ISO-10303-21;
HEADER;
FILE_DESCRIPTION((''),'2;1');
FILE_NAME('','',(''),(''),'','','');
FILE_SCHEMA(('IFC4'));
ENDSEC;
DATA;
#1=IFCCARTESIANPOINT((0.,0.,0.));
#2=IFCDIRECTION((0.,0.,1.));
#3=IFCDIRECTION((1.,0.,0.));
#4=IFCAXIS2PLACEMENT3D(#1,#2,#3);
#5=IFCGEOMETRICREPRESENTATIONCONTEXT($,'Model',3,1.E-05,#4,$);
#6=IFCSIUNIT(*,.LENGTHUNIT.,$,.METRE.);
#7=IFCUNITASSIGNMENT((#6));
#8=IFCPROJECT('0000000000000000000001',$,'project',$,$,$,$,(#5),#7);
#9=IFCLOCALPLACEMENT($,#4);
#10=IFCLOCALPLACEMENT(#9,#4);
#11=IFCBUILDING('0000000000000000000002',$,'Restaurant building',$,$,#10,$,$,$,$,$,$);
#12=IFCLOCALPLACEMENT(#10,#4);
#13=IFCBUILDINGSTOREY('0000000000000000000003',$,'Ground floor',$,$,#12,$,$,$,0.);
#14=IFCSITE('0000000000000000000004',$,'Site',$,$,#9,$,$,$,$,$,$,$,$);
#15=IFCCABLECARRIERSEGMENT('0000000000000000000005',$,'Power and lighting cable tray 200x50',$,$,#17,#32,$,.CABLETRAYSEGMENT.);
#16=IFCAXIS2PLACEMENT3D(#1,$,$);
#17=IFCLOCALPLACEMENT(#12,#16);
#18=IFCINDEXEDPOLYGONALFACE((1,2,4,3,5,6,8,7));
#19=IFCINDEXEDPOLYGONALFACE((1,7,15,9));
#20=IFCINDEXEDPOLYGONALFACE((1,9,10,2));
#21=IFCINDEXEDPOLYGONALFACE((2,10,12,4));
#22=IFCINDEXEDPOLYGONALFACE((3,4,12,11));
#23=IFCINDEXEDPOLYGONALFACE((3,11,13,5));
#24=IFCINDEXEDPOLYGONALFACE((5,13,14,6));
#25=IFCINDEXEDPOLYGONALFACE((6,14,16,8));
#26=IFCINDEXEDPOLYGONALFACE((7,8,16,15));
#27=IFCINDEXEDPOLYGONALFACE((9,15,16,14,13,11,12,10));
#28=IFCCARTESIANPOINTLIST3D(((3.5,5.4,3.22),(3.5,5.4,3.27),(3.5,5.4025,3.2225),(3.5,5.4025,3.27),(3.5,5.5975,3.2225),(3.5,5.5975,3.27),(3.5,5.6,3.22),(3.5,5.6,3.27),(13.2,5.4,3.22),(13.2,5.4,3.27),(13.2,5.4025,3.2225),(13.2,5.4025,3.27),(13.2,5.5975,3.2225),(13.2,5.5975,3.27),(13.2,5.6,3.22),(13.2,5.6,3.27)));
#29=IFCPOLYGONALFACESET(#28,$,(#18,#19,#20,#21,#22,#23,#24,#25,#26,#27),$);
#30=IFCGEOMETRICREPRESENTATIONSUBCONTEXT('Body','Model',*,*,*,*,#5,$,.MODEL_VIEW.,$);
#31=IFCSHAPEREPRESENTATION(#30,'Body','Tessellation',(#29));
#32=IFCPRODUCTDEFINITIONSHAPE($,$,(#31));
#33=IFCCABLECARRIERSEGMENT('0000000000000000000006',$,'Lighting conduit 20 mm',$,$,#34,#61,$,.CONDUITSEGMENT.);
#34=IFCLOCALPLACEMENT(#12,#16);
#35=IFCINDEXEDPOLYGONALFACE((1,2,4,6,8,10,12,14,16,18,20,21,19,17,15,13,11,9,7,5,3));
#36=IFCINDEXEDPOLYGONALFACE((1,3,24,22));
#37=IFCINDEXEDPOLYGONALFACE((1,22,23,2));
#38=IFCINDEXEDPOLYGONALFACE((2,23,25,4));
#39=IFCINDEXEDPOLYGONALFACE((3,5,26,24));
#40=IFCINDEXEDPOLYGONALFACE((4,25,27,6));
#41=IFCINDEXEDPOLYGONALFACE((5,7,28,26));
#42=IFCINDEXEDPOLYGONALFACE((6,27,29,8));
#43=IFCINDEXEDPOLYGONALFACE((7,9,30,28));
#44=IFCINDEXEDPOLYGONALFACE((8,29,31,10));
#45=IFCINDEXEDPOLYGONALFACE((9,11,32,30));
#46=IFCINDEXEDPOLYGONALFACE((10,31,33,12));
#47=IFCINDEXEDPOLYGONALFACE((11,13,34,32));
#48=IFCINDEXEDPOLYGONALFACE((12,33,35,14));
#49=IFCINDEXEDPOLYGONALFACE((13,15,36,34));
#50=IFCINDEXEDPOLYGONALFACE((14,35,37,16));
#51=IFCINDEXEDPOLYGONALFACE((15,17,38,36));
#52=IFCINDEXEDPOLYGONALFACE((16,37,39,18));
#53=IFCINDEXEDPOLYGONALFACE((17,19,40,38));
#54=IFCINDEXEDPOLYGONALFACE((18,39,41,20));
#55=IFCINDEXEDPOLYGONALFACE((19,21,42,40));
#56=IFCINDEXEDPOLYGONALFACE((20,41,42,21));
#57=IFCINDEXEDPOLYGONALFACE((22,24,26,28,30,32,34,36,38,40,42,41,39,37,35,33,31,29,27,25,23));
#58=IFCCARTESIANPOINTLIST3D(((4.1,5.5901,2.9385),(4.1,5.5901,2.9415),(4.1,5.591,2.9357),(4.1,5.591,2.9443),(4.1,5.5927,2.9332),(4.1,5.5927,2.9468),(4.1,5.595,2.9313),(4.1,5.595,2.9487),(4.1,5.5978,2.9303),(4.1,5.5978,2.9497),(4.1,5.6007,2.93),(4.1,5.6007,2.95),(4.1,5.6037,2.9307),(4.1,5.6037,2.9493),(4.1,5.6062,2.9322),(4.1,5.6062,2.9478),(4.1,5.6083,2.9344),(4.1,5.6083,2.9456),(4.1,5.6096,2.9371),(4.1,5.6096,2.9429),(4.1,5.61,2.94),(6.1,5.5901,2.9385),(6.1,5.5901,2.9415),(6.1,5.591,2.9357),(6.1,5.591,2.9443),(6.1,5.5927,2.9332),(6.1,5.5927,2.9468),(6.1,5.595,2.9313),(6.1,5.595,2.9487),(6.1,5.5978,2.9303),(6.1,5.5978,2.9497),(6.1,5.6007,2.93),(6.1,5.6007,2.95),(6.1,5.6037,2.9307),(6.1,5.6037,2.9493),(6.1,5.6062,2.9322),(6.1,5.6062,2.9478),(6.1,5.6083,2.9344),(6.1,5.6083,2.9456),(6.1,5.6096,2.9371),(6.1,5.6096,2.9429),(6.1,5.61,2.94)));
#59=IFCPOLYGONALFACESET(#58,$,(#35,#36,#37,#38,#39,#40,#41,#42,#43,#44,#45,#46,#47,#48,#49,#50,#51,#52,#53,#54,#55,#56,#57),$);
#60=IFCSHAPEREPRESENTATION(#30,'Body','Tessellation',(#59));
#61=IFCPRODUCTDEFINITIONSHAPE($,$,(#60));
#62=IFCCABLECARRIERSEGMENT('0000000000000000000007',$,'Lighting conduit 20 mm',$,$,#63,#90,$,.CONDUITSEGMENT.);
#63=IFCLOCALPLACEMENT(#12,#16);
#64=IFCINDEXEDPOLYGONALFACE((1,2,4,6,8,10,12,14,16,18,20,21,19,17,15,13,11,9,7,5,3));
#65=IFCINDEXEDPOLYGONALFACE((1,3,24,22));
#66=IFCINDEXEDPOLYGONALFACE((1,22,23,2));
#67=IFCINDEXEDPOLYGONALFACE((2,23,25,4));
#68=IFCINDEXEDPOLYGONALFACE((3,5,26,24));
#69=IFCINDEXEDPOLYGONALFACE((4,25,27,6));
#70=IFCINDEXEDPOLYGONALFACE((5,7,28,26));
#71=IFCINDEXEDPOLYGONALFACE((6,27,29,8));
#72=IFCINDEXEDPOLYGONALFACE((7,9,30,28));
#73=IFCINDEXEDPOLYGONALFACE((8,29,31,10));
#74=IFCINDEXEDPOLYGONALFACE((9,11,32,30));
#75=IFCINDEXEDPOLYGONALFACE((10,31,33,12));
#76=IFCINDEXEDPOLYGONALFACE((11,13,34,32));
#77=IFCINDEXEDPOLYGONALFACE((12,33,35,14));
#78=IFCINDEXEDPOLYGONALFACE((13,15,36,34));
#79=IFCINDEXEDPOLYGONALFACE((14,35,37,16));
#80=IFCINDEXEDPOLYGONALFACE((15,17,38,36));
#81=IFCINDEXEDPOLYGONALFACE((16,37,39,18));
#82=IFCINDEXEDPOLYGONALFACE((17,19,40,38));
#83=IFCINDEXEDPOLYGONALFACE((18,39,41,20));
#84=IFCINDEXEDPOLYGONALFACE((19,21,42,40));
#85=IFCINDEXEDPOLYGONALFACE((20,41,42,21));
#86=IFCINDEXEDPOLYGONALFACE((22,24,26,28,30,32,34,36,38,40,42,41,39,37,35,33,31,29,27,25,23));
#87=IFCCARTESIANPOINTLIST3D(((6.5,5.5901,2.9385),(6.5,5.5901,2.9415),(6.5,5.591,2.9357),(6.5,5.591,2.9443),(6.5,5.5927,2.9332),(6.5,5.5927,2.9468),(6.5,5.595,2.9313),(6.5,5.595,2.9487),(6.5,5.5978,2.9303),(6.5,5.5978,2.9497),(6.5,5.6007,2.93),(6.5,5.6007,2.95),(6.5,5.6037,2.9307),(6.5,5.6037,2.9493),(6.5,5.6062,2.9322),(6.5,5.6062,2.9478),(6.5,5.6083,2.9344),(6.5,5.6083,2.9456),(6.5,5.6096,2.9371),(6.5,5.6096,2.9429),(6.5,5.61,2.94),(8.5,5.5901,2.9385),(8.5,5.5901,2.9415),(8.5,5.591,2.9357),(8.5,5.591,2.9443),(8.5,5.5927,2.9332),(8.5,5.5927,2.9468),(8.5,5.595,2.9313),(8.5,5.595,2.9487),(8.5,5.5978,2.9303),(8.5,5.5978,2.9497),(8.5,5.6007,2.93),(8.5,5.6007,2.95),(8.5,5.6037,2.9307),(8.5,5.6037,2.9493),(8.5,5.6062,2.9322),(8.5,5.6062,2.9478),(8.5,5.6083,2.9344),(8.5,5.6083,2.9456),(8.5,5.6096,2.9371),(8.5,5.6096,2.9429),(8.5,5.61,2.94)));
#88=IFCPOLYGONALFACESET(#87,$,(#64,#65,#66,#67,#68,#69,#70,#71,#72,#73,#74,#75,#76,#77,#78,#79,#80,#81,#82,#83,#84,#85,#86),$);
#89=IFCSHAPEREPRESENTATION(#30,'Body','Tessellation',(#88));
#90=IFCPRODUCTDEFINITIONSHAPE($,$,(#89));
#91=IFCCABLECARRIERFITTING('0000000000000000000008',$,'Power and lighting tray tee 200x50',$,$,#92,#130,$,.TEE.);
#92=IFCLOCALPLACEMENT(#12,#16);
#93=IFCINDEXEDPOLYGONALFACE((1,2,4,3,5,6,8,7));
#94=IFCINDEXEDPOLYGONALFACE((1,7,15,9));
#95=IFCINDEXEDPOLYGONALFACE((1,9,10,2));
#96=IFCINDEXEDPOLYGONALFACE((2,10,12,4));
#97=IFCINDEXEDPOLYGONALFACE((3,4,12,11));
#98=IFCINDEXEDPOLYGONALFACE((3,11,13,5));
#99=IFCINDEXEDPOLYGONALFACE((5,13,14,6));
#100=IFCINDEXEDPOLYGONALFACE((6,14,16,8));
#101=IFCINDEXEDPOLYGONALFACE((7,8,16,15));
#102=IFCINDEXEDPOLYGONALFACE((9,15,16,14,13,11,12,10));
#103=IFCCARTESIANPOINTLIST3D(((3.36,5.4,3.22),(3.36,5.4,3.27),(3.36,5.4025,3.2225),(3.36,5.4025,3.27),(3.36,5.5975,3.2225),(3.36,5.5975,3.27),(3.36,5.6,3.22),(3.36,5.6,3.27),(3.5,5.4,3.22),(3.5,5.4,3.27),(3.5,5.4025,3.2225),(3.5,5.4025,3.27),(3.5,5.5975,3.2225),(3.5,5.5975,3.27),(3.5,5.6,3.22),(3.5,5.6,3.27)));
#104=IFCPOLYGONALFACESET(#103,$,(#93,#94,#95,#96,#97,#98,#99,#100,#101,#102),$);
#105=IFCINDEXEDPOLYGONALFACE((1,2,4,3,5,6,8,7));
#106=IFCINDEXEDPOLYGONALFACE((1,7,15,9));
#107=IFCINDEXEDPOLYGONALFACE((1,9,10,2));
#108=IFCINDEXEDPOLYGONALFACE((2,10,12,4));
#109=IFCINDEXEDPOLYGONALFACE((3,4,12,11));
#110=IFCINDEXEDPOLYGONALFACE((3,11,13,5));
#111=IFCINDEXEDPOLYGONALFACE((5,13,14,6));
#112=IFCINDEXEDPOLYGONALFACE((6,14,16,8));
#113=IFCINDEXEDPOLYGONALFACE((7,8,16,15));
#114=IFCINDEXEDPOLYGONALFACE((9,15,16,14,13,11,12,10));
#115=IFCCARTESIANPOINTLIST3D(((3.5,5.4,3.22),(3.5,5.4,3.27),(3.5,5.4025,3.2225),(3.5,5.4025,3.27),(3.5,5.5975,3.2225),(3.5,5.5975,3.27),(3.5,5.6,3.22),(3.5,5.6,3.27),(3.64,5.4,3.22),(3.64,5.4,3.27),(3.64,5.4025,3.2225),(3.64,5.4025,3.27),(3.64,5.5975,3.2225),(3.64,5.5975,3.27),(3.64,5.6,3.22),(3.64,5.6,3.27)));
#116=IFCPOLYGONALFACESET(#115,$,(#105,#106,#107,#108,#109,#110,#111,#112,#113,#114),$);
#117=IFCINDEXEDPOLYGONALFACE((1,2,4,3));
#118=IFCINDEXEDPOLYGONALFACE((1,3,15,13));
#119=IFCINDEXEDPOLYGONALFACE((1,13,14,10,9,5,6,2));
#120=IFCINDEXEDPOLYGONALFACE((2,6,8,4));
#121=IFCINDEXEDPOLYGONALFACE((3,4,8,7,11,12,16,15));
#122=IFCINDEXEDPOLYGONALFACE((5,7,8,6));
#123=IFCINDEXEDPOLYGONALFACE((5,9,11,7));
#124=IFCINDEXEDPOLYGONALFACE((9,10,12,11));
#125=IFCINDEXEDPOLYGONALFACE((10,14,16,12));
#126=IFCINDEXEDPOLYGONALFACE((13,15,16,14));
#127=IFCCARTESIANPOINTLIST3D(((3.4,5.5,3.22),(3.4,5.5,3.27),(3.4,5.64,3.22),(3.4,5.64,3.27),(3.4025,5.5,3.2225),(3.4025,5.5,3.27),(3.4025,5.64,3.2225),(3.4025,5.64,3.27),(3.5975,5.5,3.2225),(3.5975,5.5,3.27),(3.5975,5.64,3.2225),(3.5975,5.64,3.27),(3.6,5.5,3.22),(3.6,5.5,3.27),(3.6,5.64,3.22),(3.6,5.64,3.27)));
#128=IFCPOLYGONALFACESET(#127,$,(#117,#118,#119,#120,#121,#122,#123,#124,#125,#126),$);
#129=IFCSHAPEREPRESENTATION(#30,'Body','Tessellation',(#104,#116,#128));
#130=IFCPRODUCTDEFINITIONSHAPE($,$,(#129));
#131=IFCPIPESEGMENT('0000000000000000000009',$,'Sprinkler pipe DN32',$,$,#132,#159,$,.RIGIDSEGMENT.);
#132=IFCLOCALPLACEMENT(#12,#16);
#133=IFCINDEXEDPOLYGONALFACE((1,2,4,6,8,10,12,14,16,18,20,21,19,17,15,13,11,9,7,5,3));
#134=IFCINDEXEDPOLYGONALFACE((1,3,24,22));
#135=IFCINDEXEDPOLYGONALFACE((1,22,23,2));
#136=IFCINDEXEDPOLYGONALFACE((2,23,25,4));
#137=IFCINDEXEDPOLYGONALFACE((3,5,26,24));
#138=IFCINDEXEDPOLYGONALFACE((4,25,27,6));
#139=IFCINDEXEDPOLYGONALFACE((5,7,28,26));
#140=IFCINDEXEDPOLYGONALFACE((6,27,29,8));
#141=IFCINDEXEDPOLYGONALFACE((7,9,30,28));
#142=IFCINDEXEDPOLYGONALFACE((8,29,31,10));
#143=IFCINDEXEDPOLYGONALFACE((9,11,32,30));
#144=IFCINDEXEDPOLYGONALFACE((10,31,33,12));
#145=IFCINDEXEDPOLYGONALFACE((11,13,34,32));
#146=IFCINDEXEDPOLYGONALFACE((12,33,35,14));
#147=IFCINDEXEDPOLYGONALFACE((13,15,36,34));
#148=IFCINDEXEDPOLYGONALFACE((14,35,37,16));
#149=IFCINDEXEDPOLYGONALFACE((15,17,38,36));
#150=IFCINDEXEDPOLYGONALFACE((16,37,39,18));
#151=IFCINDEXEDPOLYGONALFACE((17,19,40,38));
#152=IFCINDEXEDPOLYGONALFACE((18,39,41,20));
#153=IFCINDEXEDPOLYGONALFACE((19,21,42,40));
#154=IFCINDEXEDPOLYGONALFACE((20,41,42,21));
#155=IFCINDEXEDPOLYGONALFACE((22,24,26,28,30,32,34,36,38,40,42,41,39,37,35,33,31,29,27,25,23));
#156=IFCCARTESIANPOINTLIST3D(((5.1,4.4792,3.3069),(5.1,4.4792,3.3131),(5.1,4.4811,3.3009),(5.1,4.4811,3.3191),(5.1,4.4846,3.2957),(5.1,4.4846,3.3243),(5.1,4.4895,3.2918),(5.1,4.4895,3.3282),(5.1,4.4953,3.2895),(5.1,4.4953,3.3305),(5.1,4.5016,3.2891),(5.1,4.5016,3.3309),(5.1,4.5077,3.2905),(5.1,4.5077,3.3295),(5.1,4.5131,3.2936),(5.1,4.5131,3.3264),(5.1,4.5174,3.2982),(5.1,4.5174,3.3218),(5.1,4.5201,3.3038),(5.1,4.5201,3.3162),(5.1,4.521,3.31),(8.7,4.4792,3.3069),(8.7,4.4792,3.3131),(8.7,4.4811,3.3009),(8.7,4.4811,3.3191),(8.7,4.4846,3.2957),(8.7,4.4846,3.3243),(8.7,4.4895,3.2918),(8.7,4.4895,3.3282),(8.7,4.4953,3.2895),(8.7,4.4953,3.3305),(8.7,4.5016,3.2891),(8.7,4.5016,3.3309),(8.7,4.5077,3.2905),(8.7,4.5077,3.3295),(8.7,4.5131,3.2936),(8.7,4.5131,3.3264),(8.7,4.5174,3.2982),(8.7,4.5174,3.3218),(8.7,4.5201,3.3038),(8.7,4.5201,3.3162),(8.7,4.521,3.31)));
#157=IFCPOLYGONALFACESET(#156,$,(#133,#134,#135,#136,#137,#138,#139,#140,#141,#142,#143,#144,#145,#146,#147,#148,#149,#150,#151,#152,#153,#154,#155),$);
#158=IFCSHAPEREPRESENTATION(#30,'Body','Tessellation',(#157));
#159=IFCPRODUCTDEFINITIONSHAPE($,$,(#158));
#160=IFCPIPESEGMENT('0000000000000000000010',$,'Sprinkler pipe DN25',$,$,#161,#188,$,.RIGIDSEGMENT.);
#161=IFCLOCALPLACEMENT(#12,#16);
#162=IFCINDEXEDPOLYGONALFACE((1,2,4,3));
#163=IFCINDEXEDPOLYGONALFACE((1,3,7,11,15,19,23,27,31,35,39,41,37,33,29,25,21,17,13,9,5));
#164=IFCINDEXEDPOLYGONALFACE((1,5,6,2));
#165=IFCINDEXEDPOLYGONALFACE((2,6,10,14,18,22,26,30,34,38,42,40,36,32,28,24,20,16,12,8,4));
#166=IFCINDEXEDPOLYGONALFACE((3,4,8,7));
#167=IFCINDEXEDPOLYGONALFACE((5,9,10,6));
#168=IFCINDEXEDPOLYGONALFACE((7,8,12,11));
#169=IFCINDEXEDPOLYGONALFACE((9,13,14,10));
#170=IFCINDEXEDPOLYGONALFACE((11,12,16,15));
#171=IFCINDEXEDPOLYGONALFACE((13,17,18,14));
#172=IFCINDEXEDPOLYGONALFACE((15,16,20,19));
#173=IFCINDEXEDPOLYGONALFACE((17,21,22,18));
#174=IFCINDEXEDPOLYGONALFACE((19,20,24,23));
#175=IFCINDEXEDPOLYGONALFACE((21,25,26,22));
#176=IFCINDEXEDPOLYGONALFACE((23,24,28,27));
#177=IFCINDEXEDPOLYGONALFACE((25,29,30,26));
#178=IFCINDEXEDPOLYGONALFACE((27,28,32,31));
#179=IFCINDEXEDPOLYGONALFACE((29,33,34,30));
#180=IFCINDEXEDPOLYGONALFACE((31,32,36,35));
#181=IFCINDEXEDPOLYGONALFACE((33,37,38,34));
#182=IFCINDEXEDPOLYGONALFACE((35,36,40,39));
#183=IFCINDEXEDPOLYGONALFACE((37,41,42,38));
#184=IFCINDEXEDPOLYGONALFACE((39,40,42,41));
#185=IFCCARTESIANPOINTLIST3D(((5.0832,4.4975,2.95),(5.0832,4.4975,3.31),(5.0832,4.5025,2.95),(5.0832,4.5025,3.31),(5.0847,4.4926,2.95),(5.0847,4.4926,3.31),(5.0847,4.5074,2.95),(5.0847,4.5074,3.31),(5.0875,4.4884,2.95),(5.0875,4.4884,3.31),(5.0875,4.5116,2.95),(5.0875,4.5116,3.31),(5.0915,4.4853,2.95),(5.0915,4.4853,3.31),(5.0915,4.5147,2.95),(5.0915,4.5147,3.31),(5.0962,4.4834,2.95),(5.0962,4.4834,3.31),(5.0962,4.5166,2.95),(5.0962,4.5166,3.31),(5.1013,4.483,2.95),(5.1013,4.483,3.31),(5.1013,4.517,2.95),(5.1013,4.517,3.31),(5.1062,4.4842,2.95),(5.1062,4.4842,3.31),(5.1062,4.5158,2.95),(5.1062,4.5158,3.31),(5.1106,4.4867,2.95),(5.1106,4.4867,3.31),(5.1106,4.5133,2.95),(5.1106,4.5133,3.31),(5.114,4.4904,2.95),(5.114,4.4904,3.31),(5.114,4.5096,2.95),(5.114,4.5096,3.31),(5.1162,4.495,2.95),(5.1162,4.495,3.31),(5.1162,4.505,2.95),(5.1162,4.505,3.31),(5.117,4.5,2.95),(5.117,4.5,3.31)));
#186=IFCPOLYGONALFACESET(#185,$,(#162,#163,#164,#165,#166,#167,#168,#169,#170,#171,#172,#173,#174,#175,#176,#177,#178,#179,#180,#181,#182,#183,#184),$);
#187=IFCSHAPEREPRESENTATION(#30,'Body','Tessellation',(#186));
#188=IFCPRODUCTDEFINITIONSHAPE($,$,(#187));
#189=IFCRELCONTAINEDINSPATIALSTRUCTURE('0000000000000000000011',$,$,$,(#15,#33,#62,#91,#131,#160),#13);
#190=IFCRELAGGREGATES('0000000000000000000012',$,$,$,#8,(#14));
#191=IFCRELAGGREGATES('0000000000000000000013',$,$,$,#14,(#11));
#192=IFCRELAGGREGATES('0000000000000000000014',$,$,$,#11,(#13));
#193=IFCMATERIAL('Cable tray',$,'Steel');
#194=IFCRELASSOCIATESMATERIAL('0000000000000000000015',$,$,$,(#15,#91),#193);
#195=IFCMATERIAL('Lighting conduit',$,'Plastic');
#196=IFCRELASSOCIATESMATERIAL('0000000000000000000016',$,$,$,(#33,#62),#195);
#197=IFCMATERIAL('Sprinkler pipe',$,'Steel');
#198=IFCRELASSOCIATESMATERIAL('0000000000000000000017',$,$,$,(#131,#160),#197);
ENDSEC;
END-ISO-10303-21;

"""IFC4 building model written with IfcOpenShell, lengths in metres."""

from ifc_helpers import new_model, si_unit, frame, origin_with_axes, origin_2d, place, context, subcontext, project, spatial, polyline, circle, outline, extrude, material, element, save


model = new_model("IFC4")

# Units and contexts
model_context = context("Model", 3, precision=1e-05, world=origin_with_axes())
body_context = subcontext(model_context, "Body", "Model", "MODEL_VIEW")
ifc_project = project(units=[si_unit("LENGTHUNIT", "METRE")], contexts=[model_context])

# Site, building, storey
site_placement = place(None, origin_with_axes())
site = spatial("IfcSite", under=ifc_project, at=site_placement, Name="Site")
building_placement = place(site_placement, origin_with_axes())
building = spatial("IfcBuilding", under=site, at=building_placement, Name="Restaurant building")
storey_placement = place(building_placement, origin_with_axes())
storey = spatial("IfcBuildingStorey", under=building, at=storey_placement, Name="Ground floor", Elevation=0.0)

# Cable carrier segments
ifc_material_1 = material(Name="Cable tray", Category="Steel")
cable_carrier_segment_1_placement = place(storey_placement, frame((3.5, 5.5, 3.245)))
element("IfcCableCarrierSegment", 1, at=cable_carrier_segment_1_placement, inside=storey, material=ifc_material_1, Name="Power and lighting cable tray 200x50", PredefinedType="CABLETRAYSEGMENT", context=body_context, shape_type="SweptSolid", body=[
    extrude(outline(polyline([(-0.1, -0.025), (0.1, -0.025), (0.1, 0.025), (0.0975, 0.025), (0.0975, -0.0225), (-0.0975, -0.0225), (-0.0975, 0.025), (-0.1, 0.025), (-0.1, -0.025)])), frame((0.0, 0.0, 0.0), z_axis=(1.0, 0.0, 0.0), x_axis=(0.0, 1.0, 0.0)), (0.0, 0.0, 1.0), 9.7),
])
ifc_material_2 = material(Name="Lighting conduit", Category="Plastic")
for number, where, name in (
    (2, (4.1, 5.6, 2.94), "Lighting conduit 20 mm"),
    (3, (6.5, 5.6, 2.94), "Lighting conduit 20 mm"),
):
    element("IfcCableCarrierSegment", number, at=place(storey_placement, frame(where)), inside=storey, material=ifc_material_2, Name=name, PredefinedType="CONDUITSEGMENT", context=body_context, shape_type="SweptSolid", body=[
        extrude(circle(Radius=0.01, at=origin_2d()), frame((0.0, 0.0, 0.0), z_axis=(1.0, 0.0, 0.0), x_axis=(0.0, 1.0, 0.0)), (0.0, 0.0, 1.0), 2.0),
    ])

# Cable carrier fitting
cable_carrier_fitting_1_placement = place(storey_placement, frame((3.5, 5.5, 3.245)))
element("IfcCableCarrierFitting", 4, at=cable_carrier_fitting_1_placement, inside=storey, material=ifc_material_1, Name="Power and lighting tray tee 200x50", PredefinedType="TEE", context=body_context, shape_type="SweptSolid", body=[
    extrude(outline(polyline([(-0.1, -0.025), (0.1, -0.025), (0.1, 0.025), (0.0975, 0.025), (0.0975, -0.0225), (-0.0975, -0.0225), (-0.0975, 0.025), (-0.1, 0.025), (-0.1, -0.025)])), frame((0.0, 0.0, 0.0), z_axis=(-1.0, 0.0, 0.0), x_axis=(0.0, -1.0, 0.0)), (0.0, 0.0, 1.0), 0.14),
    extrude(outline(polyline([(-0.1, -0.025), (0.1, -0.025), (0.1, 0.025), (0.0975, 0.025), (0.0975, -0.0225), (-0.0975, -0.0225), (-0.0975, 0.025), (-0.1, 0.025), (-0.1, -0.025)])), frame((0.0, 0.0, 0.0), z_axis=(1.0, 0.0, 0.0), x_axis=(0.0, 1.0, 0.0)), (0.0, 0.0, 1.0), 0.14),
    extrude(outline(polyline([(-0.1, -0.025), (0.1, -0.025), (0.1, 0.025), (0.0975, 0.025), (0.0975, -0.0225), (-0.0975, -0.0225), (-0.0975, 0.025), (-0.1, 0.025), (-0.1, -0.025)])), frame((0.0, 0.0, 0.0), z_axis=(0.0, 1.0, 0.0), x_axis=(-1.0, 0.0, 0.0)), (0.0, 0.0, 1.0), 0.14),
])

# Pipe segments
ifc_material_3 = material(Name="Sprinkler pipe", Category="Steel")
pipe_segment_1_placement = place(storey_placement, frame((5.1, 4.5, 3.31)))
element("IfcPipeSegment", 5, at=pipe_segment_1_placement, inside=storey, material=ifc_material_3, Name="Sprinkler pipe DN32", PredefinedType="RIGIDSEGMENT", context=body_context, shape_type="SweptSolid", body=[
    extrude(circle(Radius=0.021, at=origin_2d()), frame((0.0, 0.0, 0.0), z_axis=(1.0, 0.0, 0.0), x_axis=(0.0, 1.0, 0.0)), (0.0, 0.0, 1.0), 3.6),
])
pipe_segment_2_placement = place(storey_placement, frame((5.1, 4.5, 3.31)))
element("IfcPipeSegment", 6, at=pipe_segment_2_placement, inside=storey, material=ifc_material_3, Name="Sprinkler pipe DN25", PredefinedType="RIGIDSEGMENT", context=body_context, shape_type="SweptSolid", body=[
    extrude(circle(Radius=0.017, at=origin_2d()), frame((0.0, 0.0, 0.0), z_axis=(0.0, 0.0, -1.0), x_axis=(1.0, 0.0, 0.0)), (0.0, 0.0, 1.0), 0.36),
])

save(model, "model.ifc")
